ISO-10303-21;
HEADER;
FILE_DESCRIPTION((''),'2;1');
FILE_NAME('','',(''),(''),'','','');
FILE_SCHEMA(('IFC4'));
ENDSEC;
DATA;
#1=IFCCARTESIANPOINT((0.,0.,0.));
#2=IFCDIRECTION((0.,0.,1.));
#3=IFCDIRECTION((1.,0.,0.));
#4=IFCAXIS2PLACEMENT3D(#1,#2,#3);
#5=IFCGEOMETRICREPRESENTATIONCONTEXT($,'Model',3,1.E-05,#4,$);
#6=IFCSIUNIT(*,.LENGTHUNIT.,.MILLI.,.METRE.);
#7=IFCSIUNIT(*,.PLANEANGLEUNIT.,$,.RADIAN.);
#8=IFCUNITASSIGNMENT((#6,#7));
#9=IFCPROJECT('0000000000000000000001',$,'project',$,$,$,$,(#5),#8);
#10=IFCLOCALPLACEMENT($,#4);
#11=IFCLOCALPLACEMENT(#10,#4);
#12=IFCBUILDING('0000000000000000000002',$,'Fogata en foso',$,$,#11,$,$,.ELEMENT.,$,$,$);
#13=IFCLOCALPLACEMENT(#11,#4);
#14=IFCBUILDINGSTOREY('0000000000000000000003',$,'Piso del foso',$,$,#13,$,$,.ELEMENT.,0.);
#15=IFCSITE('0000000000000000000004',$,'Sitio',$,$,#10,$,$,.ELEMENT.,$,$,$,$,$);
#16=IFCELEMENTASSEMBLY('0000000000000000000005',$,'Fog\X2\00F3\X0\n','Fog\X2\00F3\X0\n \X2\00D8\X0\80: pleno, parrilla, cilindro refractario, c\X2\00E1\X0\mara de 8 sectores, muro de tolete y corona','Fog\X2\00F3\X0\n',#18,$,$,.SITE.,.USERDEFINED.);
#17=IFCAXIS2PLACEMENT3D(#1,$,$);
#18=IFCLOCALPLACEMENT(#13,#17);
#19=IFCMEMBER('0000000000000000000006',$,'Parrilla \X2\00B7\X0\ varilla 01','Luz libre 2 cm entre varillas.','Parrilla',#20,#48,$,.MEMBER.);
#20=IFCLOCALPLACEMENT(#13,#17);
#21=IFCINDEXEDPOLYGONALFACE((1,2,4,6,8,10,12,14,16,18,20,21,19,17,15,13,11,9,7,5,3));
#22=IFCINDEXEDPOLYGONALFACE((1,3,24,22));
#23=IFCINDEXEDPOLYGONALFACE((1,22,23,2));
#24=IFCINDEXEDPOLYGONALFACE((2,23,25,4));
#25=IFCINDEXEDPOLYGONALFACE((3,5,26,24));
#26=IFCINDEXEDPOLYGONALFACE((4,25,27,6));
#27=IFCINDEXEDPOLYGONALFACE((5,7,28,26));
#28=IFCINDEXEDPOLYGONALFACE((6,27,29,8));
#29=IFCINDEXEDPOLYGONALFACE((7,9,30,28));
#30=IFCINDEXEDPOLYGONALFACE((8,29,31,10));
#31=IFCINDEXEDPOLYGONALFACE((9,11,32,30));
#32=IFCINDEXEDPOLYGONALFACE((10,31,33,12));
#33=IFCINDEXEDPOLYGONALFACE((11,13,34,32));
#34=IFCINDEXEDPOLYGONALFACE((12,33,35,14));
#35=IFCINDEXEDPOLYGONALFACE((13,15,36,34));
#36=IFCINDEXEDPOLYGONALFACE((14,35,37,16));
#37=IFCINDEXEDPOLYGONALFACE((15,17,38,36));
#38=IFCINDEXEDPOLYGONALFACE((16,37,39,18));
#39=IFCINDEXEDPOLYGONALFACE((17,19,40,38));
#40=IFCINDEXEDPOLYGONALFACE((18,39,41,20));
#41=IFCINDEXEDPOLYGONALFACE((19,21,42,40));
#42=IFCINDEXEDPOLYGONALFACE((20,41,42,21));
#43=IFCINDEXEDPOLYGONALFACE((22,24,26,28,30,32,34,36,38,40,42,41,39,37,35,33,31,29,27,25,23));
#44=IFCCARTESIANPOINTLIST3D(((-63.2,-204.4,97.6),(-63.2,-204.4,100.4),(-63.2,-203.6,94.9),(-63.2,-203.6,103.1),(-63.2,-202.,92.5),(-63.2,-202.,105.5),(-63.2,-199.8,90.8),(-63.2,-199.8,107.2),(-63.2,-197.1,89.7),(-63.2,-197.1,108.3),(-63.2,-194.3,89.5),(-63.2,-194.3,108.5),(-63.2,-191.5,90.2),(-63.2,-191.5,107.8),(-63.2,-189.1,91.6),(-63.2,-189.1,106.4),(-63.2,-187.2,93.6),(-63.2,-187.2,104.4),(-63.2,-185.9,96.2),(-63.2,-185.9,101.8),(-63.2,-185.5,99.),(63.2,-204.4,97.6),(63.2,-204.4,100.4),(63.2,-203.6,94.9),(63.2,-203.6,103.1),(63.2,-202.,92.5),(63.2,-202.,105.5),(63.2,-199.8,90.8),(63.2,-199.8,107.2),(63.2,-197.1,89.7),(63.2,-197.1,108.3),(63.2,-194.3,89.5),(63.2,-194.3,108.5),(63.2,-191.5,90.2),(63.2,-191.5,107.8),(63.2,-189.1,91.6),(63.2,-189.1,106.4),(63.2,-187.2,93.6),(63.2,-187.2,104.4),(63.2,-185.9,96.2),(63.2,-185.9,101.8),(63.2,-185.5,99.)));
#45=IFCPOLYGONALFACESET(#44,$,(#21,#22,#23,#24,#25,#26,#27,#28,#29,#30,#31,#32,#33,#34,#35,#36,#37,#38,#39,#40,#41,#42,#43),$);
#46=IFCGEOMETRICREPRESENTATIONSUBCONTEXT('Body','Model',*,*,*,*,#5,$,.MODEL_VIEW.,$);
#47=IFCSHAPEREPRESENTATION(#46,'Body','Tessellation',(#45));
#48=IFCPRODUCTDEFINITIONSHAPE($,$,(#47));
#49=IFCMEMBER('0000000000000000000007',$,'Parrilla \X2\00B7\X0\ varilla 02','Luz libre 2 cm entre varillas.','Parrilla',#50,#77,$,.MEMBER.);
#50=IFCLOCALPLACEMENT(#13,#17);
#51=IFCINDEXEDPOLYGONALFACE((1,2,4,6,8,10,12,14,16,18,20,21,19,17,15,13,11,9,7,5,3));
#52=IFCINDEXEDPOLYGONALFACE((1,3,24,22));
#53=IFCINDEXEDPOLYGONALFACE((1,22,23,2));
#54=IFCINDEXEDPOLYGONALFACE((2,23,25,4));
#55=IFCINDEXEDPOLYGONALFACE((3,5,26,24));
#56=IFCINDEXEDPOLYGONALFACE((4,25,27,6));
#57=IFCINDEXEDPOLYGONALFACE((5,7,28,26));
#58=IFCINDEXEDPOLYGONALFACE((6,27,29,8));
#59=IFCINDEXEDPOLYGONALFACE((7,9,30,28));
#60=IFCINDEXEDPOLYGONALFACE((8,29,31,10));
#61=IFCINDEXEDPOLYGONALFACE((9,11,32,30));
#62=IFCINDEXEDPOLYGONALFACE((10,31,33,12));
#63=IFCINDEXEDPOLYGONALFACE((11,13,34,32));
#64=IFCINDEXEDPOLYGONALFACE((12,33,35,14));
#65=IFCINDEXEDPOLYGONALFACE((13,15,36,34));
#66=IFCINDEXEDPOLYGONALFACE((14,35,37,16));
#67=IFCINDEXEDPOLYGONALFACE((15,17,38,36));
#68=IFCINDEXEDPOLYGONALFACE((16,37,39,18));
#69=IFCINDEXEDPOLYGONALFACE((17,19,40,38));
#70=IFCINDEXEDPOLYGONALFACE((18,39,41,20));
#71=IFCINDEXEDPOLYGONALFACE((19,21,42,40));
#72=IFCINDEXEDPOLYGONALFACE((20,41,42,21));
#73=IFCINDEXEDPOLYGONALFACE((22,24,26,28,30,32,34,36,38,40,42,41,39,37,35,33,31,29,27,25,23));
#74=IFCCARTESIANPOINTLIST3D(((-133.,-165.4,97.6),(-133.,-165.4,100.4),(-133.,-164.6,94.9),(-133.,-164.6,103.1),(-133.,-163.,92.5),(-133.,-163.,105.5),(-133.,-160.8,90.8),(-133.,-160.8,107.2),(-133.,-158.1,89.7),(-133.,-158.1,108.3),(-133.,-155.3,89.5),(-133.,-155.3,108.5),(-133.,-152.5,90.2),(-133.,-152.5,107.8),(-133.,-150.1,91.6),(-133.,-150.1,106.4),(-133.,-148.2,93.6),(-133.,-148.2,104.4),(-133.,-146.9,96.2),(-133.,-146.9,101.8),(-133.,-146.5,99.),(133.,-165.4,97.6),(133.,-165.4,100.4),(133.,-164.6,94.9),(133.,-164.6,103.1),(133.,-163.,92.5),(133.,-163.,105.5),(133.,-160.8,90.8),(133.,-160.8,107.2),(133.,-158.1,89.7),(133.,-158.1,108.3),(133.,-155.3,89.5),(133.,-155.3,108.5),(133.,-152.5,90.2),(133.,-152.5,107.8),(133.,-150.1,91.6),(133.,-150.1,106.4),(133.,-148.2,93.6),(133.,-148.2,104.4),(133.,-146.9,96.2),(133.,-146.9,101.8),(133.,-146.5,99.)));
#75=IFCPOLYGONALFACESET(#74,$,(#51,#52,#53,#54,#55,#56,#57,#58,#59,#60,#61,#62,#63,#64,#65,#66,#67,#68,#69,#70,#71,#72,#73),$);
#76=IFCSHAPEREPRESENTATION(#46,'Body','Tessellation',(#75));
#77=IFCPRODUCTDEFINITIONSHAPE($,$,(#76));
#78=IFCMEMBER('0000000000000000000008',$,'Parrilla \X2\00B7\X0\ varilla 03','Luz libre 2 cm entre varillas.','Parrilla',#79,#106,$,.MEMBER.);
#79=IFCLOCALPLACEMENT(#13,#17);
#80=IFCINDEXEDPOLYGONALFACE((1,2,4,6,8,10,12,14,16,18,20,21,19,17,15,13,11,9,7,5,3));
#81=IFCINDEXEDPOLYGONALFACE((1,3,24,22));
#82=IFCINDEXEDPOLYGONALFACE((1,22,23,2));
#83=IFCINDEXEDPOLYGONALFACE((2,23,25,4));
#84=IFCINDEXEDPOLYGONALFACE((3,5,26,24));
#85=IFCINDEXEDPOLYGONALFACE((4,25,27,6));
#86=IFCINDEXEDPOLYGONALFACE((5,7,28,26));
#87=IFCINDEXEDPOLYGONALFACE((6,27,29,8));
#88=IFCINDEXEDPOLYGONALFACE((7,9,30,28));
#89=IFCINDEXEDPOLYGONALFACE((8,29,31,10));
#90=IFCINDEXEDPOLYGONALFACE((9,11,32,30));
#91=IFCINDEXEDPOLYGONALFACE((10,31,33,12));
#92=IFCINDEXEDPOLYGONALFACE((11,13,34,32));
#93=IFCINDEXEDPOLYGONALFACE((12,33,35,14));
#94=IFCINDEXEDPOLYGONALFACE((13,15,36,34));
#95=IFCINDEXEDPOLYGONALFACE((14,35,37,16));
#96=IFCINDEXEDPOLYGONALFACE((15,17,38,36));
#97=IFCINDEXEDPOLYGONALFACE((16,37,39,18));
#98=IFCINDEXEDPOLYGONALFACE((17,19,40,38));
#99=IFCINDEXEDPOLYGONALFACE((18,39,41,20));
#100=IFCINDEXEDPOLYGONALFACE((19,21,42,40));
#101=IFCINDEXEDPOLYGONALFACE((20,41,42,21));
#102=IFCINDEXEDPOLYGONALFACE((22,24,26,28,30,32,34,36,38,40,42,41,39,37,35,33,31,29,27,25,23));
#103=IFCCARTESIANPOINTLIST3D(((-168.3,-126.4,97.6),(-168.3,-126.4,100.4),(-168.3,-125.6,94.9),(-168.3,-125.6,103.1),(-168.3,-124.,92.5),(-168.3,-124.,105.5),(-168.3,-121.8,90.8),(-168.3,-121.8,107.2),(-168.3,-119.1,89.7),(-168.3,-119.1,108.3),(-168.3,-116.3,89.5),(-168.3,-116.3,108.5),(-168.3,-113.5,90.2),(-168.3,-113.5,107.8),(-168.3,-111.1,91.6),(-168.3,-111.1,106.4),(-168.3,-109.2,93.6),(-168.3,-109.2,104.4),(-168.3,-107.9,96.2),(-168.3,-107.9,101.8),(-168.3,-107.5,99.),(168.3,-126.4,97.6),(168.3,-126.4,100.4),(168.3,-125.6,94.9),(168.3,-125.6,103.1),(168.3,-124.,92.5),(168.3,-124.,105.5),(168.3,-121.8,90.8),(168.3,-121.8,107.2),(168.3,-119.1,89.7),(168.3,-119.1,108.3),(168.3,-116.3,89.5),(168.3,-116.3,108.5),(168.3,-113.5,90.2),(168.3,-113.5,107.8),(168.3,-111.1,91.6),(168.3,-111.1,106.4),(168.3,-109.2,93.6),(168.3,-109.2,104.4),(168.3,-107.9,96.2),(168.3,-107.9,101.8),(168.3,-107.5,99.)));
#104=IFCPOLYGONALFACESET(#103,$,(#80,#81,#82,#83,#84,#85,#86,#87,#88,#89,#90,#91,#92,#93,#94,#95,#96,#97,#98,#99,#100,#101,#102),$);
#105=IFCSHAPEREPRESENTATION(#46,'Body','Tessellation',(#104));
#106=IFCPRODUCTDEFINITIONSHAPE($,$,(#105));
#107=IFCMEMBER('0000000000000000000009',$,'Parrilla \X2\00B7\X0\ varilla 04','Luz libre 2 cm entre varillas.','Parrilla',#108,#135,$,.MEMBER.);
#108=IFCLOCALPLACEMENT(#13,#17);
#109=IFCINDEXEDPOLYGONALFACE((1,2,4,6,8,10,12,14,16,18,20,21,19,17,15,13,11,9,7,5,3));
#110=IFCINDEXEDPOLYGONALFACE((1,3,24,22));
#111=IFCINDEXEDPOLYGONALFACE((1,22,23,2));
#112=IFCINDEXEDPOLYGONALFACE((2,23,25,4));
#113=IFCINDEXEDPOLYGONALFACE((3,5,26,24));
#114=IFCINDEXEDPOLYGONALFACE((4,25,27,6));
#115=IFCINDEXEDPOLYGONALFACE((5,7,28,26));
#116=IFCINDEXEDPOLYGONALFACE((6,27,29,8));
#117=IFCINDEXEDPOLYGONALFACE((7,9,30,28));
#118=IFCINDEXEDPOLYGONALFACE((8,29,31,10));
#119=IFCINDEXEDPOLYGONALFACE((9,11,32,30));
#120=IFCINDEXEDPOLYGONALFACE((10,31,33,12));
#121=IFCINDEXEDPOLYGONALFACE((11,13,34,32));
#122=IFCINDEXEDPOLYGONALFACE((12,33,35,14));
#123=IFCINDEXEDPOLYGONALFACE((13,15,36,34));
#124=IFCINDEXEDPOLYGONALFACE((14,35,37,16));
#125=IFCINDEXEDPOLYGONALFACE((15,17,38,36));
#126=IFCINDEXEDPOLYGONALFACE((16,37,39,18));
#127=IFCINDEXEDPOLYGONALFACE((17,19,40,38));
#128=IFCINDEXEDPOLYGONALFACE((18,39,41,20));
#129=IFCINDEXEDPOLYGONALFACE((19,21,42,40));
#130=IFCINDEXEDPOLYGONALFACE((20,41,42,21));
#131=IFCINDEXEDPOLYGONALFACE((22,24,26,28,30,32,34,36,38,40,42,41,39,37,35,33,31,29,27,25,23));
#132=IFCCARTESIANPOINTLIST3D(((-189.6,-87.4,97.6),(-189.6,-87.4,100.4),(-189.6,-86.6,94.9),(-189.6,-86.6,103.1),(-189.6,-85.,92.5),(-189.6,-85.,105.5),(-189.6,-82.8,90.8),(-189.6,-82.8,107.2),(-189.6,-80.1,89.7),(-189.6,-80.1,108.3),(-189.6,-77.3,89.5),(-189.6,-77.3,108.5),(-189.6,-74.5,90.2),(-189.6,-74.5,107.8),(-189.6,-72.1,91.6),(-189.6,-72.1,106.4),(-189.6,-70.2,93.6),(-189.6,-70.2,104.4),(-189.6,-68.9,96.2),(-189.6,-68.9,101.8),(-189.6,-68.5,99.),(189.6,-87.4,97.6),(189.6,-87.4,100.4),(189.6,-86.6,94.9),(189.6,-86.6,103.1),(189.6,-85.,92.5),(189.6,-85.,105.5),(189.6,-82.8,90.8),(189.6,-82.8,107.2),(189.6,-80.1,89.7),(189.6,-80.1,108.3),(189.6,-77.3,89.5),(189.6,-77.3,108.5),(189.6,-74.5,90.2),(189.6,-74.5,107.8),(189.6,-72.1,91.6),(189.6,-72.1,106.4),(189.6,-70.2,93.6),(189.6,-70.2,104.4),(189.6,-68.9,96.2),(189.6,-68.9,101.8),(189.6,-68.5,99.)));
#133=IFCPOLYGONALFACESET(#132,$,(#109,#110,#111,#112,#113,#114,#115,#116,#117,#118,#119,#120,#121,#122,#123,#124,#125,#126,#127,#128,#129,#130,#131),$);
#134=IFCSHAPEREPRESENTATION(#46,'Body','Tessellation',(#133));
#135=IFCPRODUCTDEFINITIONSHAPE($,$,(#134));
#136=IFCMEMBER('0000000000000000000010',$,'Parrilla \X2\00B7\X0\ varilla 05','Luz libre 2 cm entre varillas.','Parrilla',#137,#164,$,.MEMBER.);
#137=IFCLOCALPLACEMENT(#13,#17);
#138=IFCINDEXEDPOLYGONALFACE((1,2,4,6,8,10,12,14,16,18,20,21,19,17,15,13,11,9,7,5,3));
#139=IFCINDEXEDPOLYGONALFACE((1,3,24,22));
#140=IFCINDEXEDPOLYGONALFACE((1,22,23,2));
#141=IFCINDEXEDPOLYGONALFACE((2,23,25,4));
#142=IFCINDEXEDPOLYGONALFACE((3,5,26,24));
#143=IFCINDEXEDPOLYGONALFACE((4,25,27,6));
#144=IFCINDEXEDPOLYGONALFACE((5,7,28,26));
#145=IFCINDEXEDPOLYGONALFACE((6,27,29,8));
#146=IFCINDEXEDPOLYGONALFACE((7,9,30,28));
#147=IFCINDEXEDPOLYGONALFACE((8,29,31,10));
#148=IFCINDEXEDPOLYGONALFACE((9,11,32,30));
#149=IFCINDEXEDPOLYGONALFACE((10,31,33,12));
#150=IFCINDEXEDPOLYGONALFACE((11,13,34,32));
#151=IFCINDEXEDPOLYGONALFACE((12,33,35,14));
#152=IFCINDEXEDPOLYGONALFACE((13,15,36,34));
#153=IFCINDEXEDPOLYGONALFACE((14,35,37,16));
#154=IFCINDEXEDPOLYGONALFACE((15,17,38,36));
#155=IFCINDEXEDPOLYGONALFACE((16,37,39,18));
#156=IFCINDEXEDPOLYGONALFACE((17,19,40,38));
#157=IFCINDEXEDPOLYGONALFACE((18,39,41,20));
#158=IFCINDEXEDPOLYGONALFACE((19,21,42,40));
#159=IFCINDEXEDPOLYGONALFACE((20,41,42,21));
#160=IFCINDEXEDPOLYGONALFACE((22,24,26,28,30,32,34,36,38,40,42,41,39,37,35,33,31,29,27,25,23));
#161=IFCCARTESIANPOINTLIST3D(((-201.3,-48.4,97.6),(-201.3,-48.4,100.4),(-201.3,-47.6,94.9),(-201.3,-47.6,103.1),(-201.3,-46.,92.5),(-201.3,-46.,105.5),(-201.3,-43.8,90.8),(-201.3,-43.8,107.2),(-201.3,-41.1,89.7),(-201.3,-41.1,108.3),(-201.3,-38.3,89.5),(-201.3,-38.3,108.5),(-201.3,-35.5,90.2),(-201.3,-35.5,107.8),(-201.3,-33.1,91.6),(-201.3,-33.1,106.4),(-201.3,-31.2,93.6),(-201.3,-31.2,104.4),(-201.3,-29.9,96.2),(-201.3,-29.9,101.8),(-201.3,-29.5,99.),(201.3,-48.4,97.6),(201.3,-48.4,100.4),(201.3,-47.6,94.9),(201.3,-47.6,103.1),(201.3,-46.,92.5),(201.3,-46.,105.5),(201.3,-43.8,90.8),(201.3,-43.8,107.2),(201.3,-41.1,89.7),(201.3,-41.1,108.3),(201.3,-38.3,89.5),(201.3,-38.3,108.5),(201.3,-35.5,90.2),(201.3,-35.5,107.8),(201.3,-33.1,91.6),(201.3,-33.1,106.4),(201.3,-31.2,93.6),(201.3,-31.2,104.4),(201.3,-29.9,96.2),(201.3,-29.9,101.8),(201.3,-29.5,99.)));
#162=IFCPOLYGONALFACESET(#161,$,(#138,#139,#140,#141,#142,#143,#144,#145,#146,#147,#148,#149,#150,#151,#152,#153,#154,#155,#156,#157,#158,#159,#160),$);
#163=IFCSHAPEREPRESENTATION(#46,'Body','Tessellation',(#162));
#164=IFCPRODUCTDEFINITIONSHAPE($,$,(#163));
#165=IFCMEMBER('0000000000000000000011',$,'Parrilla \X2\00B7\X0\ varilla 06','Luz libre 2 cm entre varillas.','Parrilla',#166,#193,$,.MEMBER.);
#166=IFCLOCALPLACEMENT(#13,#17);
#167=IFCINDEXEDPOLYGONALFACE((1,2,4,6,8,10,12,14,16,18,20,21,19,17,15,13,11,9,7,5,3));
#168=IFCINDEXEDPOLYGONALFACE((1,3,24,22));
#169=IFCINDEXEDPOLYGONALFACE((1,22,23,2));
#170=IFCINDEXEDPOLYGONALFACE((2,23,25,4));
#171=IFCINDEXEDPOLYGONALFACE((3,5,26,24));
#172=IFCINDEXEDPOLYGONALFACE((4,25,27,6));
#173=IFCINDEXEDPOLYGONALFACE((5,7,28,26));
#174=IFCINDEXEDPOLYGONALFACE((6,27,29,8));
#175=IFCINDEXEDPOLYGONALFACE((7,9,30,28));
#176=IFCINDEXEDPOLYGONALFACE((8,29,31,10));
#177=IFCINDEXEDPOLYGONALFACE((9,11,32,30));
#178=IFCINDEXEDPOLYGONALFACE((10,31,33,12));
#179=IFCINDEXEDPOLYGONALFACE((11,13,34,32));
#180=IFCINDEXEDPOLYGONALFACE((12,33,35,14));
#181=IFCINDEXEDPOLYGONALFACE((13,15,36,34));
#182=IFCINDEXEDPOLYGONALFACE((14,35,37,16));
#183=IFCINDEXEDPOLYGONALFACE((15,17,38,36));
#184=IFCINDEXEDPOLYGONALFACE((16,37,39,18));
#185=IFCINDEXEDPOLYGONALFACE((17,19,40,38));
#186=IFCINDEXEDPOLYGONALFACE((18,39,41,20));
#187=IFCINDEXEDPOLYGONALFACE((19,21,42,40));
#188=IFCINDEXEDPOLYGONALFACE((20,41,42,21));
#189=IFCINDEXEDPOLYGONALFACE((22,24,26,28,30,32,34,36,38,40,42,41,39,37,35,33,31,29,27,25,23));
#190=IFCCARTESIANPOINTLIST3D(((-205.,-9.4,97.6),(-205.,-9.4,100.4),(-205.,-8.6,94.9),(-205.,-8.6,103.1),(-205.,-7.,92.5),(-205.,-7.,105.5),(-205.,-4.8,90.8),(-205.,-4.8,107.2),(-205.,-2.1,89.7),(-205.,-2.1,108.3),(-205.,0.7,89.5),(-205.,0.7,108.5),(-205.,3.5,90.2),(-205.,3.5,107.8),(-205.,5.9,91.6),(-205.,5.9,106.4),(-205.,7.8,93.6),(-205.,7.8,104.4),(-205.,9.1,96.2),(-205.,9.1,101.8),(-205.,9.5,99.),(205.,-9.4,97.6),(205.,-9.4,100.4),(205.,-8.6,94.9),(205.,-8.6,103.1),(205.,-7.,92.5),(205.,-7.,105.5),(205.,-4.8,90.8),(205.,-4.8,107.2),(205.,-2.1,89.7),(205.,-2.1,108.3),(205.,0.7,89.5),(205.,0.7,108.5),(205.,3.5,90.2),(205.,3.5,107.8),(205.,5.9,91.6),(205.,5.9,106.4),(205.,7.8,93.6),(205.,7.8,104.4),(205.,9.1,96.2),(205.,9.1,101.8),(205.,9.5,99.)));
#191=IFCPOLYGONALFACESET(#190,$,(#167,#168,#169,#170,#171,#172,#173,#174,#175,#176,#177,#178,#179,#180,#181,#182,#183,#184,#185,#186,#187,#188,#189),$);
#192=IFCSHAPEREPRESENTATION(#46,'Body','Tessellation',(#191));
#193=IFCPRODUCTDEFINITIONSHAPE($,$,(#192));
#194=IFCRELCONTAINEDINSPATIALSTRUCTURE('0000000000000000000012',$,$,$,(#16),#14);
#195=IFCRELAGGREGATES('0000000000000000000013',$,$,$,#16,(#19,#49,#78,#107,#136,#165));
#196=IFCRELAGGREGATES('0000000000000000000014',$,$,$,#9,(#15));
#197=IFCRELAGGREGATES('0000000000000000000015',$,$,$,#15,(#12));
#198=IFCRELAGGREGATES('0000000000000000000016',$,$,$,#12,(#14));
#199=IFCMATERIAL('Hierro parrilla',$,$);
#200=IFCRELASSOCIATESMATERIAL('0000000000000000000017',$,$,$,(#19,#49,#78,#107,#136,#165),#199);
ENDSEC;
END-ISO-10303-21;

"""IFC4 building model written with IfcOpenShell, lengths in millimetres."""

from ifc_helpers import new_model, si_unit, frame, origin_with_axes, origin_2d, place, context, subcontext, project, spatial, circle, extrude, material, element, aggregate, save


model = new_model("IFC4")

# Units and contexts
model_context = context("Model", 3, precision=1e-05, world=origin_with_axes())
body_context = subcontext(model_context, "Body", "Model", "MODEL_VIEW")
ifc_project = project(units=[si_unit("LENGTHUNIT", "METRE", prefix="MILLI"), si_unit("PLANEANGLEUNIT", "RADIAN")], contexts=[model_context])

# Site, building, storey
site_placement = place(None, origin_with_axes())
site = spatial("IfcSite", under=ifc_project, at=site_placement, Name="Sitio", CompositionType="ELEMENT")
building_placement = place(site_placement, origin_with_axes())
building = spatial("IfcBuilding", under=site, at=building_placement, Name="Fogata en foso", CompositionType="ELEMENT")
storey_placement = place(building_placement, origin_with_axes())
storey = spatial("IfcBuildingStorey", under=building, at=storey_placement, Name="Piso del foso", CompositionType="ELEMENT", Elevation=0.0)

# Element assembly, members
assembly_1_placement = place(storey_placement, origin_with_axes())
assembly_1 = element("IfcElementAssembly", 1, at=assembly_1_placement, inside=storey, Name="Fogón", Description="Fogón Ø80: pleno, parrilla, cilindro refractario, cámara de 8 sectores, muro de tolete y corona", ObjectType="Fogón", AssemblyPlace="SITE", PredefinedType="USERDEFINED")
ifc_material_1 = material(Name="Hierro parrilla")
member_1_placement = place(storey_placement, frame((-63.2, -195.0, 99.0), z_axis=(1.0, 0.0, 0.0), x_axis=(0.0, 1.0, 0.0)))
member_1 = element("IfcMember", 2, at=member_1_placement, material=ifc_material_1, Name="Parrilla · varilla 01", Description="Luz libre 2 cm entre varillas.", ObjectType="Parrilla", PredefinedType="MEMBER", context=body_context, shape_type="SweptSolid", body=[
    extrude(circle(Radius=9.5, at=origin_2d()), origin_with_axes(), (0.0, 0.0, 1.0), 126.5),
])
member_2_placement = place(storey_placement, frame((-133.0, -156.0, 99.0), z_axis=(1.0, 0.0, 0.0), x_axis=(0.0, 1.0, 0.0)))
member_2 = element("IfcMember", 3, at=member_2_placement, material=ifc_material_1, Name="Parrilla · varilla 02", Description="Luz libre 2 cm entre varillas.", ObjectType="Parrilla", PredefinedType="MEMBER", context=body_context, shape_type="SweptSolid", body=[
    extrude(circle(Radius=9.5, at=origin_2d()), origin_with_axes(), (0.0, 0.0, 1.0), 266.0),
])
member_3_placement = place(storey_placement, frame((-168.3, -117.0, 99.0), z_axis=(1.0, 0.0, 0.0), x_axis=(0.0, 1.0, 0.0)))
member_3 = element("IfcMember", 4, at=member_3_placement, material=ifc_material_1, Name="Parrilla · varilla 03", Description="Luz libre 2 cm entre varillas.", ObjectType="Parrilla", PredefinedType="MEMBER", context=body_context, shape_type="SweptSolid", body=[
    extrude(circle(Radius=9.5, at=origin_2d()), origin_with_axes(), (0.0, 0.0, 1.0), 336.7),
])
member_4_placement = place(storey_placement, frame((-189.6, -78.0, 99.0), z_axis=(1.0, 0.0, 0.0), x_axis=(0.0, 1.0, 0.0)))
member_4 = element("IfcMember", 5, at=member_4_placement, material=ifc_material_1, Name="Parrilla · varilla 04", Description="Luz libre 2 cm entre varillas.", ObjectType="Parrilla", PredefinedType="MEMBER", context=body_context, shape_type="SweptSolid", body=[
    extrude(circle(Radius=9.5, at=origin_2d()), origin_with_axes(), (0.0, 0.0, 1.0), 379.2),
])
member_5_placement = place(storey_placement, frame((-201.3, -39.0, 99.0), z_axis=(1.0, 0.0, 0.0), x_axis=(0.0, 1.0, 0.0)))
member_5 = element("IfcMember", 6, at=member_5_placement, material=ifc_material_1, Name="Parrilla · varilla 05", Description="Luz libre 2 cm entre varillas.", ObjectType="Parrilla", PredefinedType="MEMBER", context=body_context, shape_type="SweptSolid", body=[
    extrude(circle(Radius=9.5, at=origin_2d()), origin_with_axes(), (0.0, 0.0, 1.0), 402.5),
])
member_6_placement = place(storey_placement, frame((-205.0, 0.0, 99.0), z_axis=(1.0, 0.0, 0.0), x_axis=(0.0, 1.0, 0.0)))
member_6 = element("IfcMember", 7, at=member_6_placement, material=ifc_material_1, Name="Parrilla · varilla 06", Description="Luz libre 2 cm entre varillas.", ObjectType="Parrilla", PredefinedType="MEMBER", context=body_context, shape_type="SweptSolid", body=[
    extrude(circle(Radius=9.5, at=origin_2d()), origin_with_axes(), (0.0, 0.0, 1.0), 410.0),
])

aggregate(assembly_1, [member_1, member_2, member_3, member_4, member_5, member_6])

save(model, "model.ifc")
